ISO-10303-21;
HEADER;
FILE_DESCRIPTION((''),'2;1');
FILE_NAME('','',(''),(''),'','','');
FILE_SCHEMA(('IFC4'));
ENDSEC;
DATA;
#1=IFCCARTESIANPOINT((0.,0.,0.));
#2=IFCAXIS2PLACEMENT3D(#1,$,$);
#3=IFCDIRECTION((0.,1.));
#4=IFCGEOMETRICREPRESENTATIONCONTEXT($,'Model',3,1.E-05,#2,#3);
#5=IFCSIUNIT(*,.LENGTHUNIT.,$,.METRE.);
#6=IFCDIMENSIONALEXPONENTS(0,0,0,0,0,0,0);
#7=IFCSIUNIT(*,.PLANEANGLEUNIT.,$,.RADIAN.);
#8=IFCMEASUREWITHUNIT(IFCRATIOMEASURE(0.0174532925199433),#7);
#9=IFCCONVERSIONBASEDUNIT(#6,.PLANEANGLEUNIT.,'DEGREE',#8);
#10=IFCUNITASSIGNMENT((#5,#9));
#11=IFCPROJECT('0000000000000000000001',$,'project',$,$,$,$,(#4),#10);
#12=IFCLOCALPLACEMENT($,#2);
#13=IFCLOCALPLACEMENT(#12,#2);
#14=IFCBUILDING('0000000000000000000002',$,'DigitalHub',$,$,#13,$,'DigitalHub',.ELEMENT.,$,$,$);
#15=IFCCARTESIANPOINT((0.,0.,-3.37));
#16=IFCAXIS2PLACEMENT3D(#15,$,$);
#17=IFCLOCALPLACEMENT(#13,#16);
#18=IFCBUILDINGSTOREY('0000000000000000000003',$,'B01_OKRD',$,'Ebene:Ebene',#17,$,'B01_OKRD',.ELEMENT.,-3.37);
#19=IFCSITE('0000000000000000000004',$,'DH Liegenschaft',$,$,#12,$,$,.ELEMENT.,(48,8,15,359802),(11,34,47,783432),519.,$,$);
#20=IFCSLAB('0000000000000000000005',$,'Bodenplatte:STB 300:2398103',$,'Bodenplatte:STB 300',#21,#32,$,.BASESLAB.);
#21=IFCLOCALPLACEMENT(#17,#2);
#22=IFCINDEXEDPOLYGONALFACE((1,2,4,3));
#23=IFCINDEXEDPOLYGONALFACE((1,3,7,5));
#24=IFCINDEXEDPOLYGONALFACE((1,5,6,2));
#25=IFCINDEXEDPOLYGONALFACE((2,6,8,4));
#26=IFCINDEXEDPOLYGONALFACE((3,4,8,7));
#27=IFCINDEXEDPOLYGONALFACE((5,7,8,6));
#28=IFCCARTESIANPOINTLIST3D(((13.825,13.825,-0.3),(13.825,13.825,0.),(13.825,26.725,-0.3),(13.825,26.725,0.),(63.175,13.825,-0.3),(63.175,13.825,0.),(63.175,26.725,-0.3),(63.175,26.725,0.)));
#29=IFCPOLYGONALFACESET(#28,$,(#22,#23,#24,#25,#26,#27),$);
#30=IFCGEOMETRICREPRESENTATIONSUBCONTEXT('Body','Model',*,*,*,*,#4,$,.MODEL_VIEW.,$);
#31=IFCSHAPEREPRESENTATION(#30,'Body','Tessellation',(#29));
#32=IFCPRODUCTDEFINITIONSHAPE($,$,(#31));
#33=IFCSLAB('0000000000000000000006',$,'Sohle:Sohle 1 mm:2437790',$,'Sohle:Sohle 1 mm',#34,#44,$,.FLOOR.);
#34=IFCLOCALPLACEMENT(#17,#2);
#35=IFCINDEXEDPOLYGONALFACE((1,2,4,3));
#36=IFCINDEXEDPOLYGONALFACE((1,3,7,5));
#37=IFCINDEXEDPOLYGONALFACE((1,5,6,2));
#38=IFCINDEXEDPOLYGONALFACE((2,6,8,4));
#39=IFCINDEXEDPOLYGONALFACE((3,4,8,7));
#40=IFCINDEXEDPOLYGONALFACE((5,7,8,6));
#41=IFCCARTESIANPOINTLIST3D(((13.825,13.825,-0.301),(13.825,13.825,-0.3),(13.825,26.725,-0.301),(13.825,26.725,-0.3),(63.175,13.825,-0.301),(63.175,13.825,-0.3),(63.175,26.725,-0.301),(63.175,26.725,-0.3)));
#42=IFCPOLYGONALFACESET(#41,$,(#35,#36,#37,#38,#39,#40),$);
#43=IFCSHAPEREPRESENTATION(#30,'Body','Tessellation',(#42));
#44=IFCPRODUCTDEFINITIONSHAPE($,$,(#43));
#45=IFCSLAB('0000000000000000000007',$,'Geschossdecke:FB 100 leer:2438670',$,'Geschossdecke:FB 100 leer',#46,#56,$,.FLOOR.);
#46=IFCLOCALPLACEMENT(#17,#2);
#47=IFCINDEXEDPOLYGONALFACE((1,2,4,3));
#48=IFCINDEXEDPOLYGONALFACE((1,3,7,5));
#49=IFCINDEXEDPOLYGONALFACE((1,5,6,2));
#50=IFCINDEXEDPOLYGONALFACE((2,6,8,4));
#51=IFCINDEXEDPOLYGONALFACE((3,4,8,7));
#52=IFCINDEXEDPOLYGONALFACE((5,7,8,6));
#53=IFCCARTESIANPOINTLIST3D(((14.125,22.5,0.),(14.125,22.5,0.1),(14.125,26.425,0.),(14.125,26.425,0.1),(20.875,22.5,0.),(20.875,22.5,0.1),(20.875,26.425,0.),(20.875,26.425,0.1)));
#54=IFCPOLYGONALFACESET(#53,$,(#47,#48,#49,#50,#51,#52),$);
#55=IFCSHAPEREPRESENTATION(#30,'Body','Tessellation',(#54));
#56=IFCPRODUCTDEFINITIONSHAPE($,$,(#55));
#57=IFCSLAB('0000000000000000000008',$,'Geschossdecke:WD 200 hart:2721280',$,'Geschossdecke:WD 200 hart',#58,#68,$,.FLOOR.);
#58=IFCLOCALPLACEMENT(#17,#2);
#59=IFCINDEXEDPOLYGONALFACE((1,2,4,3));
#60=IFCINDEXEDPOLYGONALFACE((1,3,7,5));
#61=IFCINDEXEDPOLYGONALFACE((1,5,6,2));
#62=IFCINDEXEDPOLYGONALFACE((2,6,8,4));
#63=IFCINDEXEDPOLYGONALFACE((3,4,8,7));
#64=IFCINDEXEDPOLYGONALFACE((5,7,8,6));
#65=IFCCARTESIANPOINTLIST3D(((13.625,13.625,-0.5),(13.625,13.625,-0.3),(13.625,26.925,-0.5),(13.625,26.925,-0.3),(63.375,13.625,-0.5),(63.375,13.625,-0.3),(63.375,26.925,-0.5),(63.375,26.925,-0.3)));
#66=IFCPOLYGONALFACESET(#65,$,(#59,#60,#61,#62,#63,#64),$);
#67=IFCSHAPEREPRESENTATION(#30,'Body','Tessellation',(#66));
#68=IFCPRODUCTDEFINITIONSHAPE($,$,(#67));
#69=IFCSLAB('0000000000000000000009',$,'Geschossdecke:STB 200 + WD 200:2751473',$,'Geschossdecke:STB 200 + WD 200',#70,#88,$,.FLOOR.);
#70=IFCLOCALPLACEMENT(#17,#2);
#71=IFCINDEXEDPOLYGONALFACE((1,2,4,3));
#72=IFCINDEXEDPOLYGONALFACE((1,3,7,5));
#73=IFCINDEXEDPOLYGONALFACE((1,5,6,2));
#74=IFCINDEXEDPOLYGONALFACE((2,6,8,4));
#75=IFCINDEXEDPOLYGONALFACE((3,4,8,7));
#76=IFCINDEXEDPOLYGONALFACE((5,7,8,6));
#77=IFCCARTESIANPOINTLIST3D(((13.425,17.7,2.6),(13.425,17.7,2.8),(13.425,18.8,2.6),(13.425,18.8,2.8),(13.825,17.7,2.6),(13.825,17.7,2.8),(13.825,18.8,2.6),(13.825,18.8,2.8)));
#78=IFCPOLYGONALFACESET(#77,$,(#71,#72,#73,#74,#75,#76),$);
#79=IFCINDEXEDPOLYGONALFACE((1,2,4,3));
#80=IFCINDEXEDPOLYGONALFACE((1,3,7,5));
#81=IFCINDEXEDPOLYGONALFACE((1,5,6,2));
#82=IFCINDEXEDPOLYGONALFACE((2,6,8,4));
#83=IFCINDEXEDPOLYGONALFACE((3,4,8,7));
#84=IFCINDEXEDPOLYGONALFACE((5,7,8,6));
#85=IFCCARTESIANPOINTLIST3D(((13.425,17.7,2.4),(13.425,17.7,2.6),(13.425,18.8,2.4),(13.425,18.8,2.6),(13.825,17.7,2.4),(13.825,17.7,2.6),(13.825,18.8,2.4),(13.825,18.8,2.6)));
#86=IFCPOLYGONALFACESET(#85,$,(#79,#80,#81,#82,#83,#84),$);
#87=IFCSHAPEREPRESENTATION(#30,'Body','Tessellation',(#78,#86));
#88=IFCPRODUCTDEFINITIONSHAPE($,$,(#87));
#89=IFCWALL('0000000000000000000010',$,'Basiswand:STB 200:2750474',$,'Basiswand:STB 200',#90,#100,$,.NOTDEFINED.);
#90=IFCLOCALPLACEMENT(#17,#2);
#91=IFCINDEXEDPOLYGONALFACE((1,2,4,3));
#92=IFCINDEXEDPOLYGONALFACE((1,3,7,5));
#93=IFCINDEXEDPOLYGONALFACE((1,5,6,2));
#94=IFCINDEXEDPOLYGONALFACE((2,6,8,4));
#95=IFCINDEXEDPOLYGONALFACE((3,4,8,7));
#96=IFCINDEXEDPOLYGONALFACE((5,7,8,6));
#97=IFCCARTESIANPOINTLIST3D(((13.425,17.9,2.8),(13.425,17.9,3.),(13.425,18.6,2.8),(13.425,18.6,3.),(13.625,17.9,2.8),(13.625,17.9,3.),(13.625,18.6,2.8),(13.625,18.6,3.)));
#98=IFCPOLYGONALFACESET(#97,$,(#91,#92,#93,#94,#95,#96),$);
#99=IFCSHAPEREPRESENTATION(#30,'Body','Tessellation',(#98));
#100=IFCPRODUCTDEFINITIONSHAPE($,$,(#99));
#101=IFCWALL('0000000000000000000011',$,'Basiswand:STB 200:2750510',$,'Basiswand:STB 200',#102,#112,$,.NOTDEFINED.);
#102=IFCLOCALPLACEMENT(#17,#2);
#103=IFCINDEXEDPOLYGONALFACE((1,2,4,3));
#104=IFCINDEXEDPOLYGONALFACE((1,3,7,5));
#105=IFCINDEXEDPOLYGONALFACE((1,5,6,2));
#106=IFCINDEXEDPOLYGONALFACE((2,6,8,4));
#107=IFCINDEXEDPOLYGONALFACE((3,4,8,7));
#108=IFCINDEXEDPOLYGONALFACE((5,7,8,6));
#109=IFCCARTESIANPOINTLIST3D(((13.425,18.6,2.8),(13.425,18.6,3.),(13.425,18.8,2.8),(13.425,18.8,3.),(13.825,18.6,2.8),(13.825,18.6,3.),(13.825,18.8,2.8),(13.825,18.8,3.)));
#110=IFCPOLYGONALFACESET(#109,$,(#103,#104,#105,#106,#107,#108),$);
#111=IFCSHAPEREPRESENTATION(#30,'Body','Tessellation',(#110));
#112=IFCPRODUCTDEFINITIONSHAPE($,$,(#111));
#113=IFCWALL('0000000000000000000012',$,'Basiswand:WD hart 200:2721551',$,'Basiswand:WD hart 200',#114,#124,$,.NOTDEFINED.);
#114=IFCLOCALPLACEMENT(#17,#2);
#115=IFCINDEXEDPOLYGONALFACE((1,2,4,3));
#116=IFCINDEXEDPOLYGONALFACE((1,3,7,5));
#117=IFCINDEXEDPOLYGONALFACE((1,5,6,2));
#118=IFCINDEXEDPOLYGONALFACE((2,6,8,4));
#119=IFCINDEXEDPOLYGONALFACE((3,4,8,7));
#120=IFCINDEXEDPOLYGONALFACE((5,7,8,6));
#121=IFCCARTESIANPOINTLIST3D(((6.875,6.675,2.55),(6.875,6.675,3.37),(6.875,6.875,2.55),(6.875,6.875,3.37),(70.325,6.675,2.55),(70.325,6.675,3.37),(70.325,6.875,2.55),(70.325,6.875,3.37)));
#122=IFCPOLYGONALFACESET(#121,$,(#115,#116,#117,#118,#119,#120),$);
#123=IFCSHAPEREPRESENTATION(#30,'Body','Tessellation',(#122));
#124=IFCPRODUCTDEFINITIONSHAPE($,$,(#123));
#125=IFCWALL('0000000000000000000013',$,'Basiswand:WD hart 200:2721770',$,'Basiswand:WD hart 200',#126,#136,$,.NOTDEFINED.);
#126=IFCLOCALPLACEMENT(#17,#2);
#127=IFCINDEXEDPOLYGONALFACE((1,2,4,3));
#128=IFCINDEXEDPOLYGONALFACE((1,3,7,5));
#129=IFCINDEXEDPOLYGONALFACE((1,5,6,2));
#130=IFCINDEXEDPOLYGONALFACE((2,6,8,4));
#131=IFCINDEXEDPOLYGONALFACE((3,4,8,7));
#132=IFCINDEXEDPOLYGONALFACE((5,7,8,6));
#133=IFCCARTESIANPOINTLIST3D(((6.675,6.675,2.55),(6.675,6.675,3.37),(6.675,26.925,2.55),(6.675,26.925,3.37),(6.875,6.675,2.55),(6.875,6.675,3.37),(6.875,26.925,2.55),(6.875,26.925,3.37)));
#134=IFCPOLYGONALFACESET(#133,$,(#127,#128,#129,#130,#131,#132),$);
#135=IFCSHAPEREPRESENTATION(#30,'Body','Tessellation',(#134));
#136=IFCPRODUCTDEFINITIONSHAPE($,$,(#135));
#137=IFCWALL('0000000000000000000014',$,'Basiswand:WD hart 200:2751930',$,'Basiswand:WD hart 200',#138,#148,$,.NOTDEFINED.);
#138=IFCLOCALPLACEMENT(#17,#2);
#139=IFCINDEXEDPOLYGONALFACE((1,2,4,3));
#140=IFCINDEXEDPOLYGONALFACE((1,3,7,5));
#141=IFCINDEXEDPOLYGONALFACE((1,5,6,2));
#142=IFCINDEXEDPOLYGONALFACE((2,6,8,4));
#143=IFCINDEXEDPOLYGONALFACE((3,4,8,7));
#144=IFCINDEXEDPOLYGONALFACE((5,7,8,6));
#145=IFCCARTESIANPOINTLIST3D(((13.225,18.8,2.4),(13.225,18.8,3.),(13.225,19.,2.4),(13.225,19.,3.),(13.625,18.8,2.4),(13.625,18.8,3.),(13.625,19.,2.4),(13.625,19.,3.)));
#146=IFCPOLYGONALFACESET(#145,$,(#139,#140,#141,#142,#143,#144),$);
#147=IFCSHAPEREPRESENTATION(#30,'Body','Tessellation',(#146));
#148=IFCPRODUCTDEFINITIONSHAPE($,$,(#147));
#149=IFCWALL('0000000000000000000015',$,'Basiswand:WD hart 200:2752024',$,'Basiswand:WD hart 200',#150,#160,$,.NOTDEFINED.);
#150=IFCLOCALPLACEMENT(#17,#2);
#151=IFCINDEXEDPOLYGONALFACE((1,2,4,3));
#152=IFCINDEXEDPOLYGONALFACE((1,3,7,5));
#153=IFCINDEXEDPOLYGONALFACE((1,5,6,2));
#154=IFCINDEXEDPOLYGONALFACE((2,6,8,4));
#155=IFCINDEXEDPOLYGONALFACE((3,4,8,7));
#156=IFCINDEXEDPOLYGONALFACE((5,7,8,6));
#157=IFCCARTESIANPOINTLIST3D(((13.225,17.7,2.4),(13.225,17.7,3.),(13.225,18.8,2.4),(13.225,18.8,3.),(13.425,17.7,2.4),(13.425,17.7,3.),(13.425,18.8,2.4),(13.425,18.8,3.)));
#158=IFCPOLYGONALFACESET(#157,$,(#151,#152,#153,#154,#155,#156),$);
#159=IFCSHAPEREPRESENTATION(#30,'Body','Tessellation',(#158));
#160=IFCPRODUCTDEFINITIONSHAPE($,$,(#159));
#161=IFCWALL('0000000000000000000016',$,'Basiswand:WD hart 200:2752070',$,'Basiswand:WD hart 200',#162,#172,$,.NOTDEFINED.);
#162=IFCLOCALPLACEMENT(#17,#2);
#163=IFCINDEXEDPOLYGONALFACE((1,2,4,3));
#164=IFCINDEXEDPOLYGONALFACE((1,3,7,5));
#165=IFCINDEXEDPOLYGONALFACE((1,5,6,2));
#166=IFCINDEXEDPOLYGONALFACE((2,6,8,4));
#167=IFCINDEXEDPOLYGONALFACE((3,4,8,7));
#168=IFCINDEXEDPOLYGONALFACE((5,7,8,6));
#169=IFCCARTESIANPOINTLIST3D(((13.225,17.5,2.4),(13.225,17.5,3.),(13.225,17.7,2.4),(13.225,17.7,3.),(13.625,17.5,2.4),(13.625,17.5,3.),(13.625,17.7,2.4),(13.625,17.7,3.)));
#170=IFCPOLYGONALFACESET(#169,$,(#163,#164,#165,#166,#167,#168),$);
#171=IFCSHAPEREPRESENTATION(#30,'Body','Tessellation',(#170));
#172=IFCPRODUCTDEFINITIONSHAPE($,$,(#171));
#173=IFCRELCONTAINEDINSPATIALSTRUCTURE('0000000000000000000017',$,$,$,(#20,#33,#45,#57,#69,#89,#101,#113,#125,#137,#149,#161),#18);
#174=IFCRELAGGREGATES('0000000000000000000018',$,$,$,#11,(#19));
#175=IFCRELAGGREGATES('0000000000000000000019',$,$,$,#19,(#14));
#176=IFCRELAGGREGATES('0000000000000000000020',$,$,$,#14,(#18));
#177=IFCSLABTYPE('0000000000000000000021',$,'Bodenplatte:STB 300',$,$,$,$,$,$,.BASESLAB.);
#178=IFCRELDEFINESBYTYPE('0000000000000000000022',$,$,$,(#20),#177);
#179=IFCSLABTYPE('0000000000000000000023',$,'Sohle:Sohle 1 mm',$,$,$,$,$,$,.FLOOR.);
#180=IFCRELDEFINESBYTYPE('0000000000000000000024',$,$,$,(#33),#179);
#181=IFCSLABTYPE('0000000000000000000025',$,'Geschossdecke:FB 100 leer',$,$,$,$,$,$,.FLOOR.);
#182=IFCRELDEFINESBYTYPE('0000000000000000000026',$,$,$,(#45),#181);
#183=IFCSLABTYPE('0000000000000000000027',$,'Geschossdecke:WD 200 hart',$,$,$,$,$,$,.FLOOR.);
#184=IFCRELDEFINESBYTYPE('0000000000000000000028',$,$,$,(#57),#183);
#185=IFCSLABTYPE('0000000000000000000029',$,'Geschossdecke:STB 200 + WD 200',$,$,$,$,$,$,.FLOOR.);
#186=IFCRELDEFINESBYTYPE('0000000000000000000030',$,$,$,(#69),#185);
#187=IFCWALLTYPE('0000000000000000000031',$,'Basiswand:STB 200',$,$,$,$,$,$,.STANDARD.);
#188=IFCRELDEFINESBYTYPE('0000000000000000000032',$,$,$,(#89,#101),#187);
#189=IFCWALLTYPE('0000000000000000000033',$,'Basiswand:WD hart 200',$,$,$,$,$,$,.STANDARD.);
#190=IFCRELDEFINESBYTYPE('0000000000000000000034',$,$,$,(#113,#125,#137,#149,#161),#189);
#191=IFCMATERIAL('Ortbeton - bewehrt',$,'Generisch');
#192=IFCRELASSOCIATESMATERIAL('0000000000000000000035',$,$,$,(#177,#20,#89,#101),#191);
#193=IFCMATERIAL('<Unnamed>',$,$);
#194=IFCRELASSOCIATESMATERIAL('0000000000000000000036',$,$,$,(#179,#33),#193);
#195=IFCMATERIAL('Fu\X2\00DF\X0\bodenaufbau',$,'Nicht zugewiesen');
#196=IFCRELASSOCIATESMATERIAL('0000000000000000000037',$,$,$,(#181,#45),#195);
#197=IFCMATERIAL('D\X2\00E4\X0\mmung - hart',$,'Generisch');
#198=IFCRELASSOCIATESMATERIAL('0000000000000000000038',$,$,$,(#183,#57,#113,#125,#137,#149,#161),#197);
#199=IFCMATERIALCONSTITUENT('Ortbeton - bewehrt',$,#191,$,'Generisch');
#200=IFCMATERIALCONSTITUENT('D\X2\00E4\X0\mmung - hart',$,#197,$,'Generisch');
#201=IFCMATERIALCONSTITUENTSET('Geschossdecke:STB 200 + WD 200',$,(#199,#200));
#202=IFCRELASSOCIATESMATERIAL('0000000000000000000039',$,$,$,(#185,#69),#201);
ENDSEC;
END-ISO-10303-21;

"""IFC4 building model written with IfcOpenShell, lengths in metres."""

from ifc_helpers import new_model, entity, si_unit, converted_unit, direction, frame, origin, place, context, subcontext, project, spatial, indexed_curve, outline, extrude, material, constituent, constituent_set, type_object, element, save


model = new_model("IFC4")

# Units and contexts
model_context = context("Model", 3, precision=1e-05, world=origin(), true_north=direction((0.0, 1.0)))
body_context = subcontext(model_context, "Body", "Model", "MODEL_VIEW")
ifc_project = project(units=[si_unit("LENGTHUNIT", "METRE"), converted_unit("PLANEANGLEUNIT", "DEGREE", entity("IfcRatioMeasure", 0.0174532925199433), si_unit("PLANEANGLEUNIT", "RADIAN"), dimensions=[0, 0, 0, 0, 0, 0, 0])], contexts=[model_context])

# Site, building, storey
site_placement = place(None, frame((0.0, 0.0, 0.0)))
site = spatial("IfcSite", under=ifc_project, at=site_placement, Name="DH Liegenschaft", CompositionType="ELEMENT", RefLatitude=(48, 8, 15, 359802), RefLongitude=(11, 34, 47, 783432), RefElevation=519.0)
building_placement = place(site_placement, origin())
building = spatial("IfcBuilding", under=site, at=building_placement, Name="DigitalHub", LongName="DigitalHub", CompositionType="ELEMENT")
storey_placement = place(building_placement, frame((0.0, 0.0, -3.37)))
storey = spatial("IfcBuildingStorey", under=building, at=storey_placement, Name="B01_OKRD", ObjectType="Ebene:Ebene", LongName="B01_OKRD", CompositionType="ELEMENT", Elevation=-3.37)

# Slabs
ifc_material_1 = material(Name="Ortbeton - bewehrt", Category="Generisch")
slab_type_1 = type_object("IfcSlabType", Name="Bodenplatte:STB 300", PredefinedType="BASESLAB", material=ifc_material_1)
slab_1_placement = place(storey_placement, origin())
element("IfcSlab", 1, at=slab_1_placement, inside=storey, type_object=slab_type_1, material=ifc_material_1, Name="Bodenplatte:STB 300:2398103", ObjectType="Bodenplatte:STB 300", PredefinedType="BASESLAB", context=body_context, shape_type="SweptSolid", body=[
    extrude(outline(indexed_curve([(-6.45, -24.675), (6.45, -24.675), (6.45, 24.675), (-6.45, 24.675), (-6.45, -24.675)], self_intersect=False)), frame((38.5, 20.275, 0.0), z_axis=(0.0, 0.0, -1.0), x_axis=(0.0, 1.0, 0.0)), (0.0, 0.0, 1.0), 0.3),
])
ifc_material_2 = material(Name="<Unnamed>")
slab_type_2 = type_object("IfcSlabType", Name="Sohle:Sohle 1 mm", PredefinedType="FLOOR", material=ifc_material_2)
slab_2_placement = place(storey_placement, origin())
element("IfcSlab", 2, at=slab_2_placement, inside=storey, type_object=slab_type_2, material=ifc_material_2, Name="Sohle:Sohle 1 mm:2437790", ObjectType="Sohle:Sohle 1 mm", PredefinedType="FLOOR", context=body_context, shape_type="SweptSolid", body=[
    extrude(outline(indexed_curve([(-6.45, -24.675), (6.45, -24.675), (6.45, 24.675), (-6.45, 24.675), (-6.45, -24.675)], self_intersect=False)), frame((38.5, 20.275, -0.301), z_axis=(0.0, 0.0, 1.0), x_axis=(0.0, 1.0, 0.0)), (0.0, 0.0, 1.0), 0.001),
])
ifc_material_3 = material(Name="Fußbodenaufbau", Category="Nicht zugewiesen")
slab_type_3 = type_object("IfcSlabType", Name="Geschossdecke:FB 100 leer", PredefinedType="FLOOR", material=ifc_material_3)
slab_3_placement = place(storey_placement, origin())
element("IfcSlab", 3, at=slab_3_placement, inside=storey, type_object=slab_type_3, material=ifc_material_3, Name="Geschossdecke:FB 100 leer:2438670", ObjectType="Geschossdecke:FB 100 leer", PredefinedType="FLOOR", context=body_context, shape_type="SweptSolid", body=[
    extrude(outline(indexed_curve([(-1.9625, -3.375), (1.9625, -3.375), (1.9625, 3.375), (-1.9625, 3.375), (-1.9625, -3.375)], self_intersect=False)), frame((17.5, 24.4625, 0.1), z_axis=(0.0, 0.0, -1.0), x_axis=(0.0, 1.0, 0.0)), (0.0, 0.0, 1.0), 0.1),
])
ifc_material_4 = material(Name="Dämmung - hart", Category="Generisch")
slab_type_4 = type_object("IfcSlabType", Name="Geschossdecke:WD 200 hart", PredefinedType="FLOOR", material=ifc_material_4)
slab_4_placement = place(storey_placement, origin())
element("IfcSlab", 4, at=slab_4_placement, inside=storey, type_object=slab_type_4, material=ifc_material_4, Name="Geschossdecke:WD 200 hart:2721280", ObjectType="Geschossdecke:WD 200 hart", PredefinedType="FLOOR", context=body_context, shape_type="SweptSolid", body=[
    extrude(outline(indexed_curve([(-6.65, -24.875), (6.65, -24.875), (6.65, 24.875), (-6.65, 24.875), (-6.65, -24.875)], self_intersect=False)), frame((38.5, 20.275, -0.3), z_axis=(0.0, 0.0, -1.0), x_axis=(0.0, 1.0, 0.0)), (0.0, 0.0, 1.0), 0.2),
])
ifc_constituent_1 = constituent(ifc_material_1, Name="Ortbeton - bewehrt", Category="Generisch")
ifc_constituent_2 = constituent(ifc_material_4, Name="Dämmung - hart", Category="Generisch")
ifc_constituent_set = constituent_set(constituents=[ifc_constituent_1, ifc_constituent_2], Name="Geschossdecke:STB 200 + WD 200")
slab_type_5 = type_object("IfcSlabType", Name="Geschossdecke:STB 200 + WD 200", PredefinedType="FLOOR", material=ifc_constituent_set)
slab_5_placement = place(storey_placement, origin())
element("IfcSlab", 5, at=slab_5_placement, inside=storey, type_object=slab_type_5, material=ifc_constituent_set, Name="Geschossdecke:STB 200 + WD 200:2751473", ObjectType="Geschossdecke:STB 200 + WD 200", PredefinedType="FLOOR", context=body_context, shape_type="SweptSolid", body=[
    extrude(outline(indexed_curve([(-0.2, -0.55), (0.2, -0.55), (0.2, 0.55), (-0.2, 0.55), (-0.2, -0.55)], self_intersect=False)), frame((13.625, 18.25, 2.6), z_axis=(0.0, 0.0, 1.0), x_axis=(-1.0, 0.0, 0.0)), (0.0, 0.0, 1.0), 0.2),
    extrude(outline(indexed_curve([(-0.2, -0.55), (0.2, -0.55), (0.2, 0.55), (-0.2, 0.55), (-0.2, -0.55)], self_intersect=False)), frame((13.625, 18.25, 2.4), z_axis=(0.0, 0.0, 1.0), x_axis=(-1.0, 0.0, 0.0)), (0.0, 0.0, 1.0), 0.2),
])

# Walls
wall_type_1 = type_object("IfcWallType", Name="Basiswand:STB 200", PredefinedType="STANDARD")
wall_1_placement = place(storey_placement, frame((13.525, 17.9, 2.8), z_axis=(0.0, 0.0, 1.0), x_axis=(0.0, 1.0, 0.0)))
element("IfcWall", 6, at=wall_1_placement, inside=storey, type_object=wall_type_1, material=ifc_material_1, Name="Basiswand:STB 200:2750474", ObjectType="Basiswand:STB 200", PredefinedType="NOTDEFINED", context=body_context, shape_type="SweptSolid", body=[
    extrude(outline(indexed_curve([(0.7, 0.1), (0.0, 0.1), (0.0, -0.1), (0.7, -0.1), (0.7, 0.1)], self_intersect=False)), origin(), (0.0, 0.0, 1.0), 0.2),
])
wall_2_placement = place(storey_placement, frame((13.425, 18.7, 2.8)))
element("IfcWall", 7, at=wall_2_placement, inside=storey, type_object=wall_type_1, material=ifc_material_1, Name="Basiswand:STB 200:2750510", ObjectType="Basiswand:STB 200", PredefinedType="NOTDEFINED", context=body_context, shape_type="SweptSolid", body=[
    extrude(outline(indexed_curve([(0.4, 0.1), (0.0, 0.1), (0.0, -0.1), (0.4, -0.1), (0.4, 0.1)], self_intersect=False)), origin(), (0.0, 0.0, 1.0), 0.2),
])
wall_type_2 = type_object("IfcWallType", Name="Basiswand:WD hart 200", PredefinedType="STANDARD")
wall_3_placement = place(storey_placement, frame((6.875, 6.775, 2.55)))
element("IfcWall", 8, at=wall_3_placement, inside=storey, type_object=wall_type_2, material=ifc_material_4, Name="Basiswand:WD hart 200:2721551", ObjectType="Basiswand:WD hart 200", PredefinedType="NOTDEFINED", context=body_context, shape_type="SweptSolid", body=[
    extrude(outline(indexed_curve([(63.45, 0.1), (0.0, 0.1), (0.0, -0.1), (63.45, -0.1), (63.45, 0.1)], self_intersect=False)), origin(), (0.0, 0.0, 1.0), 0.82),
])
wall_4_placement = place(storey_placement, frame((6.775, 6.675, 2.55), z_axis=(0.0, 0.0, 1.0), x_axis=(0.0, 1.0, 0.0)))
element("IfcWall", 9, at=wall_4_placement, inside=storey, type_object=wall_type_2, material=ifc_material_4, Name="Basiswand:WD hart 200:2721770", ObjectType="Basiswand:WD hart 200", PredefinedType="NOTDEFINED", context=body_context, shape_type="SweptSolid", body=[
    extrude(outline(indexed_curve([(20.25, 0.1), (0.0, 0.1), (0.0, -0.1), (20.25, -0.1), (20.25, 0.1)], self_intersect=False)), origin(), (0.0, 0.0, 1.0), 0.82),
])
wall_5_placement = place(storey_placement, frame((13.625, 18.9, 2.4), z_axis=(0.0, 0.0, 1.0), x_axis=(-1.0, 0.0, 0.0)))
element("IfcWall", 10, at=wall_5_placement, inside=storey, type_object=wall_type_2, material=ifc_material_4, Name="Basiswand:WD hart 200:2751930", ObjectType="Basiswand:WD hart 200", PredefinedType="NOTDEFINED", context=body_context, shape_type="SweptSolid", body=[
    extrude(outline(indexed_curve([(0.4, 0.1), (0.0, 0.1), (0.0, -0.1), (0.4, -0.1), (0.4, 0.1)], self_intersect=False)), origin(), (0.0, 0.0, 1.0), 0.6),
])
wall_6_placement = place(storey_placement, frame((13.325, 18.8, 2.4), z_axis=(0.0, 0.0, 1.0), x_axis=(0.0, -1.0, 0.0)))
element("IfcWall", 11, at=wall_6_placement, inside=storey, type_object=wall_type_2, material=ifc_material_4, Name="Basiswand:WD hart 200:2752024", ObjectType="Basiswand:WD hart 200", PredefinedType="NOTDEFINED", context=body_context, shape_type="SweptSolid", body=[
    extrude(outline(indexed_curve([(1.1, 0.1), (0.0, 0.1), (0.0, -0.1), (1.1, -0.1), (1.1, 0.1)], self_intersect=False)), origin(), (0.0, 0.0, 1.0), 0.6),
])
wall_7_placement = place(storey_placement, frame((13.225, 17.6, 2.4)))
element("IfcWall", 12, at=wall_7_placement, inside=storey, type_object=wall_type_2, material=ifc_material_4, Name="Basiswand:WD hart 200:2752070", ObjectType="Basiswand:WD hart 200", PredefinedType="NOTDEFINED", context=body_context, shape_type="SweptSolid", body=[
    extrude(outline(indexed_curve([(0.4, 0.1), (0.0, 0.1), (0.0, -0.1), (0.4, -0.1), (0.4, 0.1)], self_intersect=False)), origin(), (0.0, 0.0, 1.0), 0.6),
])

save(model, "model.ifc")
